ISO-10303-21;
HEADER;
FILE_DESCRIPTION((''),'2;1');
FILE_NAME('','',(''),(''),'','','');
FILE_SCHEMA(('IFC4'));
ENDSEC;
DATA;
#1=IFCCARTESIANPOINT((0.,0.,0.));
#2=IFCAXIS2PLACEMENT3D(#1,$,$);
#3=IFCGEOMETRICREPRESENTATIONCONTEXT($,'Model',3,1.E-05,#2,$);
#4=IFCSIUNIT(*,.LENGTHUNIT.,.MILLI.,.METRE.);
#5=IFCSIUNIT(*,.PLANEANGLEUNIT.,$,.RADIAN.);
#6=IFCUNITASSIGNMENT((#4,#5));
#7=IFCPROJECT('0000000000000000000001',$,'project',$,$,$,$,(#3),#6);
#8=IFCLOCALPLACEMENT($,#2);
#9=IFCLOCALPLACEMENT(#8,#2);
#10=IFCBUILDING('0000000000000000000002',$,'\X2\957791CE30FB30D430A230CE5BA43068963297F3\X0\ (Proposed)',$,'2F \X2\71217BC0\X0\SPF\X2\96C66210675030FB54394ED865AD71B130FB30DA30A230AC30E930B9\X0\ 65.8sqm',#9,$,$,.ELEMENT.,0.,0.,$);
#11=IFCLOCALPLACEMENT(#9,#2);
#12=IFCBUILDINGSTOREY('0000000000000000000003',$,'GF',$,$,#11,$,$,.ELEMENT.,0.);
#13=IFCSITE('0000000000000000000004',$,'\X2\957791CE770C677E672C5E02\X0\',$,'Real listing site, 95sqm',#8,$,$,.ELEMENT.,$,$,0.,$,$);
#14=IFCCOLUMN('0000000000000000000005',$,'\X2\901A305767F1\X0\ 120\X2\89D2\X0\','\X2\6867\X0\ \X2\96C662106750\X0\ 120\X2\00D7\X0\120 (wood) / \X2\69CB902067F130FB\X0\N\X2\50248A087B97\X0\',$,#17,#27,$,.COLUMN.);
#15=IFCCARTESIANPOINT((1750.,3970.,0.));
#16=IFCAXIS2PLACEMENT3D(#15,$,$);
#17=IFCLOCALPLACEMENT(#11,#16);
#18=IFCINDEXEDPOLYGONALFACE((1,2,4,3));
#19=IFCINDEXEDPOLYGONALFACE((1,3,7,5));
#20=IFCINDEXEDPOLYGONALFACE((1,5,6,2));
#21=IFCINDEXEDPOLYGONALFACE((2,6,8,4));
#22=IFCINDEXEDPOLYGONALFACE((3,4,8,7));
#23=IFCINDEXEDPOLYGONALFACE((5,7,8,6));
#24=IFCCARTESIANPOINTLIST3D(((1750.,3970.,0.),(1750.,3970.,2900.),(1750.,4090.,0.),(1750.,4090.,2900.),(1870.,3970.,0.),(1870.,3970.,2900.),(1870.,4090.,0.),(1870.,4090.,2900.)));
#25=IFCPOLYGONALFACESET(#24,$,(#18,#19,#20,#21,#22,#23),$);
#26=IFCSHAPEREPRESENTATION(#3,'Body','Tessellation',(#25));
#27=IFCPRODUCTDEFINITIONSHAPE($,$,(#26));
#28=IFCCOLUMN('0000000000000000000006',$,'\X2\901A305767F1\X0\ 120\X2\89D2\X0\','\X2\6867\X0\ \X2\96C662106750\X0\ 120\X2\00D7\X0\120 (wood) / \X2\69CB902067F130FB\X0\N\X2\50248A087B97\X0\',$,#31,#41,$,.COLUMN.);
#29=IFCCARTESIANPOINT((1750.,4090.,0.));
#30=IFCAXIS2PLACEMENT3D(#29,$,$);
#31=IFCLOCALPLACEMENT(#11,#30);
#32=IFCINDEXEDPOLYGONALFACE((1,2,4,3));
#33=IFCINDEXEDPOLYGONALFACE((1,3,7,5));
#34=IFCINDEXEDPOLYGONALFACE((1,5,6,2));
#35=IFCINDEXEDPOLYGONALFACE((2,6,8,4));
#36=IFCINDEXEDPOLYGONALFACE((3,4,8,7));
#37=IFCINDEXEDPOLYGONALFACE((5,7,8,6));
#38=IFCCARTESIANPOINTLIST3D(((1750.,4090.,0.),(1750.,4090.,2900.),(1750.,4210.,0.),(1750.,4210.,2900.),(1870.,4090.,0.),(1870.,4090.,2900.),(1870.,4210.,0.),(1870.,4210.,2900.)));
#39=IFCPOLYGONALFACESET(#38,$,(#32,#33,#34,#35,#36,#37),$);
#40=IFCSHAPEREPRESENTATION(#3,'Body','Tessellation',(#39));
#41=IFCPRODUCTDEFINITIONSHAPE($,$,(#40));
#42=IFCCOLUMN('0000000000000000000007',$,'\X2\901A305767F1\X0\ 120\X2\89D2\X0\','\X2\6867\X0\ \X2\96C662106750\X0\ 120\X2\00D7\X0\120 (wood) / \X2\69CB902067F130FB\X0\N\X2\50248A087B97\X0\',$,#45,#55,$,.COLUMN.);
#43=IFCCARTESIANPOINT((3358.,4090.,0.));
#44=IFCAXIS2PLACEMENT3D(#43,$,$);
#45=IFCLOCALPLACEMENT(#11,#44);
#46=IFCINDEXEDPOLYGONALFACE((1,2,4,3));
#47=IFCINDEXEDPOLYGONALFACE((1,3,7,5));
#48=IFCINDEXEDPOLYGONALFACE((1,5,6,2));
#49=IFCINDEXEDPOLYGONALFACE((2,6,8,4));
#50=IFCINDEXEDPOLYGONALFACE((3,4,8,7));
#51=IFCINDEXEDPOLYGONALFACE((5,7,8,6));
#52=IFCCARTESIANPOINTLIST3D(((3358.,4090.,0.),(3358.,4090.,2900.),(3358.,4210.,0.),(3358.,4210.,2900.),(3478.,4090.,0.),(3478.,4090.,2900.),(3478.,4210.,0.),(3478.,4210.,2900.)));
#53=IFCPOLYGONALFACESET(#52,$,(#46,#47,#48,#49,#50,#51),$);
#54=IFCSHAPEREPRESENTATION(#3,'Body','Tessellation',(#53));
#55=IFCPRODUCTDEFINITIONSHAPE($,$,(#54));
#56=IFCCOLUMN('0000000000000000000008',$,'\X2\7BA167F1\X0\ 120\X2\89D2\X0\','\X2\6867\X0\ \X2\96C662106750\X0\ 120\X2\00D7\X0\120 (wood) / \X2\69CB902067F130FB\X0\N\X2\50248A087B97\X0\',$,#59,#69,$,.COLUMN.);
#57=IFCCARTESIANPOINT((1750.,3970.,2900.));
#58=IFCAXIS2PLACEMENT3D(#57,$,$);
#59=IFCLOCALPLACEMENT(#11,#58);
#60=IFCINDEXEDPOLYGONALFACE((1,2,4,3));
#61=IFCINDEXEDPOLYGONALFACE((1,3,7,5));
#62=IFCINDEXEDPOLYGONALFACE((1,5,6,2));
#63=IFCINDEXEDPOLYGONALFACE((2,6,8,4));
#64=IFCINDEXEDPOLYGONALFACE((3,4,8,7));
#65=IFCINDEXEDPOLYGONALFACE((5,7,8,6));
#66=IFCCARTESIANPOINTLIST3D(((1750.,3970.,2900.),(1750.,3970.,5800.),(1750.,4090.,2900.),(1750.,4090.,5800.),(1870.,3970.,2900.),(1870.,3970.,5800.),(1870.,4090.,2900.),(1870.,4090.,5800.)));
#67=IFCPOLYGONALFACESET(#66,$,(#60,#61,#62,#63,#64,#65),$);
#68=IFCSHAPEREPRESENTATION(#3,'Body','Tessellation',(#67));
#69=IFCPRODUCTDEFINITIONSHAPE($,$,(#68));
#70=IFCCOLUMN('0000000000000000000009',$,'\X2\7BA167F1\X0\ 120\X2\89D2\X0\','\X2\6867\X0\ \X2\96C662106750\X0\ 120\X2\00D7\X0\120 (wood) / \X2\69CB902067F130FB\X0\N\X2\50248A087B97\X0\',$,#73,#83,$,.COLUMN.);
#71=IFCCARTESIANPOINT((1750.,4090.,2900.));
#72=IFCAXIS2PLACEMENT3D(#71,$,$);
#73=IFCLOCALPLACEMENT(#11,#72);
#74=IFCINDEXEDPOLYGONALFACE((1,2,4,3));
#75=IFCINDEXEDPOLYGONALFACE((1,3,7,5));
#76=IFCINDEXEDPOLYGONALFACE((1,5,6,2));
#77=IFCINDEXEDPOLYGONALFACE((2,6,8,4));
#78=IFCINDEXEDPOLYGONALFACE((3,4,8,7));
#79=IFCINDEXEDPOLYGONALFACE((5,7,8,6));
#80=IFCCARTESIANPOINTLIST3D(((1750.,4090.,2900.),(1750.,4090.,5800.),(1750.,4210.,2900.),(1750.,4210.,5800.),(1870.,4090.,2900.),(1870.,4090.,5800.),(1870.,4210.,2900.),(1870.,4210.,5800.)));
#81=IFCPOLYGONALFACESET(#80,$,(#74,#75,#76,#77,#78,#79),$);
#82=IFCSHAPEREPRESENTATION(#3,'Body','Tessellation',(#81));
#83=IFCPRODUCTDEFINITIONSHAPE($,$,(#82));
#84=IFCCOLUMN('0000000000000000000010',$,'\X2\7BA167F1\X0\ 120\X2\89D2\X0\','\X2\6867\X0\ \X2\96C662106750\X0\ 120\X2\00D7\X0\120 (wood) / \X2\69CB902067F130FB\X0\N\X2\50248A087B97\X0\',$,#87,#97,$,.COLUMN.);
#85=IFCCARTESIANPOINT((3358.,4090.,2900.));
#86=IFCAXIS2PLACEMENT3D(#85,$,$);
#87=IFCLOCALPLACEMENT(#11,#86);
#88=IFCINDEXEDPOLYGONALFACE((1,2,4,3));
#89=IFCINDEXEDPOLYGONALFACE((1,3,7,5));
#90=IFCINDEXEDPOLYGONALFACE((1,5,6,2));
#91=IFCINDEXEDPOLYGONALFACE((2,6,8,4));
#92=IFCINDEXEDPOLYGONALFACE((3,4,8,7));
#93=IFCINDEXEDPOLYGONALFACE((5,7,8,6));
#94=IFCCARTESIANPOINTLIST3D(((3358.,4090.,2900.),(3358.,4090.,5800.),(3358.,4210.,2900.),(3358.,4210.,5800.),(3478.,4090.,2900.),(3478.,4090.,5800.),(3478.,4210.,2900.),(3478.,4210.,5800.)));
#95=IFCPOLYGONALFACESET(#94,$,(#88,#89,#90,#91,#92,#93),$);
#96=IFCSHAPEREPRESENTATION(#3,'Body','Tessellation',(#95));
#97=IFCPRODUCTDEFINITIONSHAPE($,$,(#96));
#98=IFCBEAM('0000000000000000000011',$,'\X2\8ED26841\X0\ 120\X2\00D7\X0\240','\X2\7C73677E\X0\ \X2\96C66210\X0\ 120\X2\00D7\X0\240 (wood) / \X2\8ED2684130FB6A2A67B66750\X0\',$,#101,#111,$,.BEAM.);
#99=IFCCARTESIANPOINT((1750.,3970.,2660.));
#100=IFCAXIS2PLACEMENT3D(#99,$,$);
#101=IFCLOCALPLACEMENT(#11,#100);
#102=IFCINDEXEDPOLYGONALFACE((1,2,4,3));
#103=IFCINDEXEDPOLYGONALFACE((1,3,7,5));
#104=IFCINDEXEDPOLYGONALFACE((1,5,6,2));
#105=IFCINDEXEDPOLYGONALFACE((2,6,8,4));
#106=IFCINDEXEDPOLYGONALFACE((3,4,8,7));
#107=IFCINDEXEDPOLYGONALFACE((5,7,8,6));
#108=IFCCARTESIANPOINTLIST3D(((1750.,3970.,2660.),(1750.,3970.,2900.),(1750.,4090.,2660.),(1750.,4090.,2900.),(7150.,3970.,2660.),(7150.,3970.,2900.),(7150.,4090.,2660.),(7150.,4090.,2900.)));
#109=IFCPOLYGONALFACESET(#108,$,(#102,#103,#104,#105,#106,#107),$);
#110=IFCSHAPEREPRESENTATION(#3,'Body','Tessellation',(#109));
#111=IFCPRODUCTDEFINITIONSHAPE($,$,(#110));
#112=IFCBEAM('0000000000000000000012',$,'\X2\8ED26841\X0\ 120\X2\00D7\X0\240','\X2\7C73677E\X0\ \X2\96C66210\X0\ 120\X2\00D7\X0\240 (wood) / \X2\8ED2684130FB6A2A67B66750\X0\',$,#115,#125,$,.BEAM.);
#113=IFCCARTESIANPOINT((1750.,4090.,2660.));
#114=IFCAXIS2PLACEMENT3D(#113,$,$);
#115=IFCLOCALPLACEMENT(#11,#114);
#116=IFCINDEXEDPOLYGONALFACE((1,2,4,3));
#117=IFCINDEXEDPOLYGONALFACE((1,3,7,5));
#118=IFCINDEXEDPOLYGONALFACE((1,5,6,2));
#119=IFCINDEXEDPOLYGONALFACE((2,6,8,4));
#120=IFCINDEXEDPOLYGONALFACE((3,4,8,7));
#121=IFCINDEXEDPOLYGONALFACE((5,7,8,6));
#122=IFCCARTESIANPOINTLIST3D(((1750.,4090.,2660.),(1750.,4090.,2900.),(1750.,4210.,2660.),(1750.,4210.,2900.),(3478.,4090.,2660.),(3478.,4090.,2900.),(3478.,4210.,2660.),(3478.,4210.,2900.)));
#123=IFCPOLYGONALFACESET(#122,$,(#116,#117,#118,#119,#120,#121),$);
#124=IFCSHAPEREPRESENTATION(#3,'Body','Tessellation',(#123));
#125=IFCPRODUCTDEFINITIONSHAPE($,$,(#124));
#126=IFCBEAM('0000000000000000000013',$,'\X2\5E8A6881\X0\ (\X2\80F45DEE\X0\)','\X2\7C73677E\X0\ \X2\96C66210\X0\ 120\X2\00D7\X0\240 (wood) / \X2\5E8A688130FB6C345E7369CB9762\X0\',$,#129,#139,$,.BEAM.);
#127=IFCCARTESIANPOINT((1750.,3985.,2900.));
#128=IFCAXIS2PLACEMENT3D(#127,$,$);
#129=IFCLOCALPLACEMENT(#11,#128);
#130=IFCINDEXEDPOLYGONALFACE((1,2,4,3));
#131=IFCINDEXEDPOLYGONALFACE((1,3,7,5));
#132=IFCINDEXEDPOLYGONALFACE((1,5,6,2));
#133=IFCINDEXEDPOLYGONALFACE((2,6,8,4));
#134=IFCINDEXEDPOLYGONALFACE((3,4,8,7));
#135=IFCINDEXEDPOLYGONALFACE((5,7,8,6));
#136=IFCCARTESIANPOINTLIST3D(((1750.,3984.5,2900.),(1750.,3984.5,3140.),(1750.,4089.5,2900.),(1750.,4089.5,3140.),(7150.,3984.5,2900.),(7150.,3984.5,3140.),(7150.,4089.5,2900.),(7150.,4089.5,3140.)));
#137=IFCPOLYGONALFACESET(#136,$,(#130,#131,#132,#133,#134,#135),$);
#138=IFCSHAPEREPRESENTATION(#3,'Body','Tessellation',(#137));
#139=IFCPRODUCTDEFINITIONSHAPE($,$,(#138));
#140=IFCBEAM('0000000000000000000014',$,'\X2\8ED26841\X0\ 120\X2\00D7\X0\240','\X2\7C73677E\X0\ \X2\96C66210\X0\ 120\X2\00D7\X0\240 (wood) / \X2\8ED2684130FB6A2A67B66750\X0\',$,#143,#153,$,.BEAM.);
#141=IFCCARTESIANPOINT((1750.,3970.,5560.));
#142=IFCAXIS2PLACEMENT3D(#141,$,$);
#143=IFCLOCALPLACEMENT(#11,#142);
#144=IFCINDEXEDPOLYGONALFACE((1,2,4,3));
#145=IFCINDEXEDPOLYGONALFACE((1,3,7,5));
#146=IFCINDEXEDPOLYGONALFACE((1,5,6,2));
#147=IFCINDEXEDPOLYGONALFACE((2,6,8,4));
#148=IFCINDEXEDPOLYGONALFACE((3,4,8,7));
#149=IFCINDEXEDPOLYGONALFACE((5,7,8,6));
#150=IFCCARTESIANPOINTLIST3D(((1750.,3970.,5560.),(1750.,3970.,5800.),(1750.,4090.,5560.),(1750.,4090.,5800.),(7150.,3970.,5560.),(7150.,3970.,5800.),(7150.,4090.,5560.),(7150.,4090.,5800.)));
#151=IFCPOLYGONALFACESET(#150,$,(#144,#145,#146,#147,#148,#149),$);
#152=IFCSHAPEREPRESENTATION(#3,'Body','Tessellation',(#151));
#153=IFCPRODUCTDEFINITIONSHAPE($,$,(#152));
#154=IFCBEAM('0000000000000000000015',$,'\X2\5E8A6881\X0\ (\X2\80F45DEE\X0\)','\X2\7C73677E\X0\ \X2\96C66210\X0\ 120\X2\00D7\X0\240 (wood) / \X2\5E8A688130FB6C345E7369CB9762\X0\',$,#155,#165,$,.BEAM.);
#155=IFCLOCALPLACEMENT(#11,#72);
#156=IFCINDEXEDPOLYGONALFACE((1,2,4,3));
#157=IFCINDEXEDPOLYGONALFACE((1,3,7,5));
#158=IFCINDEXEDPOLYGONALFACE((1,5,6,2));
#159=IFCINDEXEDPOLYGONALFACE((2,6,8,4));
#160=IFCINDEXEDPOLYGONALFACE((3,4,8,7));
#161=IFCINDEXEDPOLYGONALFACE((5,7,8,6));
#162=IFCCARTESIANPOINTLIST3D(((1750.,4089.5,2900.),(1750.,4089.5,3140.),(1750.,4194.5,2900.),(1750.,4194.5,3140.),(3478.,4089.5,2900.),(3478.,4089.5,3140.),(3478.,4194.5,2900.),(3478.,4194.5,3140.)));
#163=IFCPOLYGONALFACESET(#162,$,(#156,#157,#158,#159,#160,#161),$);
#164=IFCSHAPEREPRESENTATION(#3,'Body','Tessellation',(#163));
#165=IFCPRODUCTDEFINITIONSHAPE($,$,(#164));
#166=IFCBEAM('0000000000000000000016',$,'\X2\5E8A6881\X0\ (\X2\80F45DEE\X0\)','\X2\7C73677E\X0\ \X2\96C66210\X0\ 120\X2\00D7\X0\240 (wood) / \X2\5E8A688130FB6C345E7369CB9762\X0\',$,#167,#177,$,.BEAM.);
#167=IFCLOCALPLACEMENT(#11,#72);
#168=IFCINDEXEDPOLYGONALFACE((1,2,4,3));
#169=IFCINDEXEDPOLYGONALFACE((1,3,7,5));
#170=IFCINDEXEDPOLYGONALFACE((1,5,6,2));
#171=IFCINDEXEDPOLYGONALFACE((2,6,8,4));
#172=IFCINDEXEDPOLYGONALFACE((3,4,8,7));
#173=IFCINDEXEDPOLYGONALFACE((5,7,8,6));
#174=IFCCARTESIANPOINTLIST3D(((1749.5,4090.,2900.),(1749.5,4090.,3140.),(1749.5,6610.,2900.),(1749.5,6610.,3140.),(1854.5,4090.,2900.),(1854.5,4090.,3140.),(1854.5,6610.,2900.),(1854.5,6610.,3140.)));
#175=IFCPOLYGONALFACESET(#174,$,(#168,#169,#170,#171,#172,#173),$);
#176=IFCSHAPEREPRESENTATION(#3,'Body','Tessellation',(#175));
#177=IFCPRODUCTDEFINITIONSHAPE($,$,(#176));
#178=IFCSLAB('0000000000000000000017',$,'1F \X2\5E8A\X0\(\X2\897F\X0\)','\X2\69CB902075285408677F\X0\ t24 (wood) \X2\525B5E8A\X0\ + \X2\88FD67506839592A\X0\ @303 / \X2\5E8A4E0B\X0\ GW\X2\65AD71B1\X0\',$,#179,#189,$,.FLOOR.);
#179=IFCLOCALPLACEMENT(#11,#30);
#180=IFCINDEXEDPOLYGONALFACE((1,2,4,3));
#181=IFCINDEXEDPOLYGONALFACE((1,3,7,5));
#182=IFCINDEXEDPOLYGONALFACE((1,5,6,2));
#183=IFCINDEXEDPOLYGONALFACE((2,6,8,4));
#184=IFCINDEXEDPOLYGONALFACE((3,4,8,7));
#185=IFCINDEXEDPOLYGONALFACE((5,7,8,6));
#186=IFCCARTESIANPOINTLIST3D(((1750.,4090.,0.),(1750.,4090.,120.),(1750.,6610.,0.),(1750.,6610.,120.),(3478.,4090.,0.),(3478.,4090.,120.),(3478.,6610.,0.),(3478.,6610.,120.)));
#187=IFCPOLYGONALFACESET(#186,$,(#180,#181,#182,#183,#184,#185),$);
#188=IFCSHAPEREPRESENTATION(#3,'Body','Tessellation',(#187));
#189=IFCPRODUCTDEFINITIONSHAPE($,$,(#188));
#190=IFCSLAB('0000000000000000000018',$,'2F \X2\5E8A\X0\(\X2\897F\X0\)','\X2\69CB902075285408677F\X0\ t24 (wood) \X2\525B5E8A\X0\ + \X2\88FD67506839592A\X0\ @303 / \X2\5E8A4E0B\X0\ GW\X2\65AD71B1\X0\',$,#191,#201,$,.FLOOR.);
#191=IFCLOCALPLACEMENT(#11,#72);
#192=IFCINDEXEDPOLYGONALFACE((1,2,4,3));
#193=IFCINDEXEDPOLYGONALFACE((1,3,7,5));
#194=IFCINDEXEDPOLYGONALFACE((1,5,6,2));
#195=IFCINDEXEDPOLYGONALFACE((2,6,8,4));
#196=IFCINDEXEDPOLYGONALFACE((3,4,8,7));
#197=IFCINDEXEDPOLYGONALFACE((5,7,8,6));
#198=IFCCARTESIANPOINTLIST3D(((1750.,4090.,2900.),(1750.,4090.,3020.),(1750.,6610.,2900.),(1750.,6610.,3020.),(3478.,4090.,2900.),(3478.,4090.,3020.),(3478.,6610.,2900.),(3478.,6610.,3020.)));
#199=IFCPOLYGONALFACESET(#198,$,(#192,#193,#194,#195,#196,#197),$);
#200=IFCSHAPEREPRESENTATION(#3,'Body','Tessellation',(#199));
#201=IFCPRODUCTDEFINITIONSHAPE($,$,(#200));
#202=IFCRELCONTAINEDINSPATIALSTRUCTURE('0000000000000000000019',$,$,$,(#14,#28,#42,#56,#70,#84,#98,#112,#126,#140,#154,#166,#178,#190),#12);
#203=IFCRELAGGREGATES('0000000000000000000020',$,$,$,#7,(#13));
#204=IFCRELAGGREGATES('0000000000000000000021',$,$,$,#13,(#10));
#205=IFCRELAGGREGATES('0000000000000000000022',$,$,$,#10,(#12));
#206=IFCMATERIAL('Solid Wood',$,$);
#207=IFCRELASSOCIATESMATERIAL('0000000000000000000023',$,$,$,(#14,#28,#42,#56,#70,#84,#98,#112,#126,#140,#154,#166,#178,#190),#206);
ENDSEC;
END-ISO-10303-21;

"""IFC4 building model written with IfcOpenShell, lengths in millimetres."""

from ifc_helpers import new_model, si_unit, frame, frame_2d, origin, place, context, project, spatial, rectangle, extrude, material, element, save


model = new_model("IFC4")

# Units and contexts
model_context = context("Model", 3, precision=1e-05, world=origin())
ifc_project = project(units=[si_unit("LENGTHUNIT", "METRE", prefix="MILLI"), si_unit("PLANEANGLEUNIT", "RADIAN")], contexts=[model_context])

# Site, building, storey
site_placement = place(None, origin())
site = spatial("IfcSite", under=ifc_project, at=site_placement, Name="長野県松本市", ObjectType="Real listing site, 95sqm", CompositionType="ELEMENT", RefElevation=0.0)
building_placement = place(site_placement, origin())
building = spatial("IfcBuilding", under=site, at=building_placement, Name="長野・ピアノ室と防音 (Proposed)", ObjectType="2F 無節SPF集成材・吹付断熱・ペアガラス 65.8sqm", CompositionType="ELEMENT", ElevationOfRefHeight=0.0, ElevationOfTerrain=0.0)
storey_placement = place(building_placement, origin())
storey = spatial("IfcBuildingStorey", under=building, at=storey_placement, Name="GF", CompositionType="ELEMENT", Elevation=0.0)

# Columns
ifc_material_1 = material(Name="Solid Wood")
column_1_placement = place(storey_placement, frame((1750.0, 3970.0, 0.0)))
element("IfcColumn", 1, at=column_1_placement, inside=storey, material=ifc_material_1, Name="通し柱 120角", Description="桧 集成材 120×120 (wood) / 構造柱・N値計算", PredefinedType="COLUMN", context=model_context, shape_type="SweptSolid", body=[
    extrude(rectangle(XDim=120.0, YDim=120.0, at=frame_2d((60.0, 60.0))), frame((1750.0, 3970.0, 0.0)), (0.0, 0.0, 1.0), 2900.0),
])
column_2_placement = place(storey_placement, frame((1750.0, 4090.0, 0.0)))
element("IfcColumn", 2, at=column_2_placement, inside=storey, material=ifc_material_1, Name="通し柱 120角", Description="桧 集成材 120×120 (wood) / 構造柱・N値計算", PredefinedType="COLUMN", context=model_context, shape_type="SweptSolid", body=[
    extrude(rectangle(XDim=120.0, YDim=120.0, at=frame_2d((60.0, 60.0))), frame((1750.0, 4090.0, 0.0)), (0.0, 0.0, 1.0), 2900.0),
])
column_3_placement = place(storey_placement, frame((3358.0, 4090.0, 0.0)))
element("IfcColumn", 3, at=column_3_placement, inside=storey, material=ifc_material_1, Name="通し柱 120角", Description="桧 集成材 120×120 (wood) / 構造柱・N値計算", PredefinedType="COLUMN", context=model_context, shape_type="SweptSolid", body=[
    extrude(rectangle(XDim=120.0, YDim=120.0, at=frame_2d((60.0, 60.0))), frame((3358.0, 4090.0, 0.0)), (0.0, 0.0, 1.0), 2900.0),
])
column_4_placement = place(storey_placement, frame((1750.0, 3970.0, 2900.0)))
element("IfcColumn", 4, at=column_4_placement, inside=storey, material=ifc_material_1, Name="管柱 120角", Description="桧 集成材 120×120 (wood) / 構造柱・N値計算", PredefinedType="COLUMN", context=model_context, shape_type="SweptSolid", body=[
    extrude(rectangle(XDim=120.0, YDim=120.0, at=frame_2d((60.0, 60.0))), frame((1750.0, 3970.0, 2900.0)), (0.0, 0.0, 1.0), 2900.0),
])
column_5_placement = place(storey_placement, frame((1750.0, 4090.0, 2900.0)))
element("IfcColumn", 5, at=column_5_placement, inside=storey, material=ifc_material_1, Name="管柱 120角", Description="桧 集成材 120×120 (wood) / 構造柱・N値計算", PredefinedType="COLUMN", context=model_context, shape_type="SweptSolid", body=[
    extrude(rectangle(XDim=120.0, YDim=120.0, at=frame_2d((60.0, 60.0))), frame((1750.0, 4090.0, 2900.0)), (0.0, 0.0, 1.0), 2900.0),
])
column_6_placement = place(storey_placement, frame((3358.0, 4090.0, 2900.0)))
element("IfcColumn", 6, at=column_6_placement, inside=storey, material=ifc_material_1, Name="管柱 120角", Description="桧 集成材 120×120 (wood) / 構造柱・N値計算", PredefinedType="COLUMN", context=model_context, shape_type="SweptSolid", body=[
    extrude(rectangle(XDim=120.0, YDim=120.0, at=frame_2d((60.0, 60.0))), frame((3358.0, 4090.0, 2900.0)), (0.0, 0.0, 1.0), 2900.0),
])

# Beams
beam_1_placement = place(storey_placement, frame((1750.0, 3970.0, 2660.0)))
element("IfcBeam", 7, at=beam_1_placement, inside=storey, material=ifc_material_1, Name="軒桁 120×240", Description="米松 集成 120×240 (wood) / 軒桁・横架材", PredefinedType="BEAM", context=model_context, shape_type="SweptSolid", body=[
    extrude(rectangle(XDim=5400.0, YDim=120.0, at=frame_2d((2700.0, 60.0))), frame((1750.0, 3970.0, 2660.0)), (0.0, 0.0, 1.0), 240.0),
])
beam_2_placement = place(storey_placement, frame((1750.0, 4090.0, 2660.0)))
element("IfcBeam", 8, at=beam_2_placement, inside=storey, material=ifc_material_1, Name="軒桁 120×240", Description="米松 集成 120×240 (wood) / 軒桁・横架材", PredefinedType="BEAM", context=model_context, shape_type="SweptSolid", body=[
    extrude(rectangle(XDim=1728.0, YDim=120.0, at=frame_2d((864.0, 60.0))), frame((1750.0, 4090.0, 2660.0)), (0.0, 0.0, 1.0), 240.0),
])
beam_3_placement = place(storey_placement, frame((1750.0, 3985.0, 2900.0)))
element("IfcBeam", 9, at=beam_3_placement, inside=storey, material=ifc_material_1, Name="床梁 (胴差)", Description="米松 集成 120×240 (wood) / 床梁・水平構面", PredefinedType="BEAM", context=model_context, shape_type="SweptSolid", body=[
    extrude(rectangle(XDim=5400.0, YDim=105.0, at=frame_2d((2700.0, 52.0))), frame((1750.0, 3985.0, 2900.0)), (0.0, 0.0, 1.0), 240.0),
])
beam_4_placement = place(storey_placement, frame((1750.0, 3970.0, 5560.0)))
element("IfcBeam", 10, at=beam_4_placement, inside=storey, material=ifc_material_1, Name="軒桁 120×240", Description="米松 集成 120×240 (wood) / 軒桁・横架材", PredefinedType="BEAM", context=model_context, shape_type="SweptSolid", body=[
    extrude(rectangle(XDim=5400.0, YDim=120.0, at=frame_2d((2700.0, 60.0))), frame((1750.0, 3970.0, 5560.0)), (0.0, 0.0, 1.0), 240.0),
])
beam_5_placement = place(storey_placement, frame((1750.0, 4090.0, 2900.0)))
element("IfcBeam", 11, at=beam_5_placement, inside=storey, material=ifc_material_1, Name="床梁 (胴差)", Description="米松 集成 120×240 (wood) / 床梁・水平構面", PredefinedType="BEAM", context=model_context, shape_type="SweptSolid", body=[
    extrude(rectangle(XDim=1728.0, YDim=105.0, at=frame_2d((864.0, 52.0))), frame((1750.0, 4090.0, 2900.0)), (0.0, 0.0, 1.0), 240.0),
])
beam_6_placement = place(storey_placement, frame((1750.0, 4090.0, 2900.0)))
element("IfcBeam", 12, at=beam_6_placement, inside=storey, material=ifc_material_1, Name="床梁 (胴差)", Description="米松 集成 120×240 (wood) / 床梁・水平構面", PredefinedType="BEAM", context=model_context, shape_type="SweptSolid", body=[
    extrude(rectangle(XDim=105.0, YDim=2520.0, at=frame_2d((52.0, 1260.0))), frame((1750.0, 4090.0, 2900.0)), (0.0, 0.0, 1.0), 240.0),
])

# Slabs
slab_1_placement = place(storey_placement, frame((1750.0, 4090.0, 0.0)))
element("IfcSlab", 13, at=slab_1_placement, inside=storey, material=ifc_material_1, Name="1F 床(西)", Description="構造用合板 t24 (wood) 剛床 + 製材根太 @303 / 床下 GW断熱", PredefinedType="FLOOR", context=model_context, shape_type="SweptSolid", body=[
    extrude(rectangle(XDim=1728.0, YDim=2520.0, at=frame_2d((864.0, 1260.0))), frame((1750.0, 4090.0, 0.0)), (0.0, 0.0, 1.0), 120.0),
])
slab_2_placement = place(storey_placement, frame((1750.0, 4090.0, 2900.0)))
element("IfcSlab", 14, at=slab_2_placement, inside=storey, material=ifc_material_1, Name="2F 床(西)", Description="構造用合板 t24 (wood) 剛床 + 製材根太 @303 / 床下 GW断熱", PredefinedType="FLOOR", context=model_context, shape_type="SweptSolid", body=[
    extrude(rectangle(XDim=1728.0, YDim=2520.0, at=frame_2d((864.0, 1260.0))), frame((1750.0, 4090.0, 2900.0)), (0.0, 0.0, 1.0), 120.0),
])

save(model, "model.ifc")
